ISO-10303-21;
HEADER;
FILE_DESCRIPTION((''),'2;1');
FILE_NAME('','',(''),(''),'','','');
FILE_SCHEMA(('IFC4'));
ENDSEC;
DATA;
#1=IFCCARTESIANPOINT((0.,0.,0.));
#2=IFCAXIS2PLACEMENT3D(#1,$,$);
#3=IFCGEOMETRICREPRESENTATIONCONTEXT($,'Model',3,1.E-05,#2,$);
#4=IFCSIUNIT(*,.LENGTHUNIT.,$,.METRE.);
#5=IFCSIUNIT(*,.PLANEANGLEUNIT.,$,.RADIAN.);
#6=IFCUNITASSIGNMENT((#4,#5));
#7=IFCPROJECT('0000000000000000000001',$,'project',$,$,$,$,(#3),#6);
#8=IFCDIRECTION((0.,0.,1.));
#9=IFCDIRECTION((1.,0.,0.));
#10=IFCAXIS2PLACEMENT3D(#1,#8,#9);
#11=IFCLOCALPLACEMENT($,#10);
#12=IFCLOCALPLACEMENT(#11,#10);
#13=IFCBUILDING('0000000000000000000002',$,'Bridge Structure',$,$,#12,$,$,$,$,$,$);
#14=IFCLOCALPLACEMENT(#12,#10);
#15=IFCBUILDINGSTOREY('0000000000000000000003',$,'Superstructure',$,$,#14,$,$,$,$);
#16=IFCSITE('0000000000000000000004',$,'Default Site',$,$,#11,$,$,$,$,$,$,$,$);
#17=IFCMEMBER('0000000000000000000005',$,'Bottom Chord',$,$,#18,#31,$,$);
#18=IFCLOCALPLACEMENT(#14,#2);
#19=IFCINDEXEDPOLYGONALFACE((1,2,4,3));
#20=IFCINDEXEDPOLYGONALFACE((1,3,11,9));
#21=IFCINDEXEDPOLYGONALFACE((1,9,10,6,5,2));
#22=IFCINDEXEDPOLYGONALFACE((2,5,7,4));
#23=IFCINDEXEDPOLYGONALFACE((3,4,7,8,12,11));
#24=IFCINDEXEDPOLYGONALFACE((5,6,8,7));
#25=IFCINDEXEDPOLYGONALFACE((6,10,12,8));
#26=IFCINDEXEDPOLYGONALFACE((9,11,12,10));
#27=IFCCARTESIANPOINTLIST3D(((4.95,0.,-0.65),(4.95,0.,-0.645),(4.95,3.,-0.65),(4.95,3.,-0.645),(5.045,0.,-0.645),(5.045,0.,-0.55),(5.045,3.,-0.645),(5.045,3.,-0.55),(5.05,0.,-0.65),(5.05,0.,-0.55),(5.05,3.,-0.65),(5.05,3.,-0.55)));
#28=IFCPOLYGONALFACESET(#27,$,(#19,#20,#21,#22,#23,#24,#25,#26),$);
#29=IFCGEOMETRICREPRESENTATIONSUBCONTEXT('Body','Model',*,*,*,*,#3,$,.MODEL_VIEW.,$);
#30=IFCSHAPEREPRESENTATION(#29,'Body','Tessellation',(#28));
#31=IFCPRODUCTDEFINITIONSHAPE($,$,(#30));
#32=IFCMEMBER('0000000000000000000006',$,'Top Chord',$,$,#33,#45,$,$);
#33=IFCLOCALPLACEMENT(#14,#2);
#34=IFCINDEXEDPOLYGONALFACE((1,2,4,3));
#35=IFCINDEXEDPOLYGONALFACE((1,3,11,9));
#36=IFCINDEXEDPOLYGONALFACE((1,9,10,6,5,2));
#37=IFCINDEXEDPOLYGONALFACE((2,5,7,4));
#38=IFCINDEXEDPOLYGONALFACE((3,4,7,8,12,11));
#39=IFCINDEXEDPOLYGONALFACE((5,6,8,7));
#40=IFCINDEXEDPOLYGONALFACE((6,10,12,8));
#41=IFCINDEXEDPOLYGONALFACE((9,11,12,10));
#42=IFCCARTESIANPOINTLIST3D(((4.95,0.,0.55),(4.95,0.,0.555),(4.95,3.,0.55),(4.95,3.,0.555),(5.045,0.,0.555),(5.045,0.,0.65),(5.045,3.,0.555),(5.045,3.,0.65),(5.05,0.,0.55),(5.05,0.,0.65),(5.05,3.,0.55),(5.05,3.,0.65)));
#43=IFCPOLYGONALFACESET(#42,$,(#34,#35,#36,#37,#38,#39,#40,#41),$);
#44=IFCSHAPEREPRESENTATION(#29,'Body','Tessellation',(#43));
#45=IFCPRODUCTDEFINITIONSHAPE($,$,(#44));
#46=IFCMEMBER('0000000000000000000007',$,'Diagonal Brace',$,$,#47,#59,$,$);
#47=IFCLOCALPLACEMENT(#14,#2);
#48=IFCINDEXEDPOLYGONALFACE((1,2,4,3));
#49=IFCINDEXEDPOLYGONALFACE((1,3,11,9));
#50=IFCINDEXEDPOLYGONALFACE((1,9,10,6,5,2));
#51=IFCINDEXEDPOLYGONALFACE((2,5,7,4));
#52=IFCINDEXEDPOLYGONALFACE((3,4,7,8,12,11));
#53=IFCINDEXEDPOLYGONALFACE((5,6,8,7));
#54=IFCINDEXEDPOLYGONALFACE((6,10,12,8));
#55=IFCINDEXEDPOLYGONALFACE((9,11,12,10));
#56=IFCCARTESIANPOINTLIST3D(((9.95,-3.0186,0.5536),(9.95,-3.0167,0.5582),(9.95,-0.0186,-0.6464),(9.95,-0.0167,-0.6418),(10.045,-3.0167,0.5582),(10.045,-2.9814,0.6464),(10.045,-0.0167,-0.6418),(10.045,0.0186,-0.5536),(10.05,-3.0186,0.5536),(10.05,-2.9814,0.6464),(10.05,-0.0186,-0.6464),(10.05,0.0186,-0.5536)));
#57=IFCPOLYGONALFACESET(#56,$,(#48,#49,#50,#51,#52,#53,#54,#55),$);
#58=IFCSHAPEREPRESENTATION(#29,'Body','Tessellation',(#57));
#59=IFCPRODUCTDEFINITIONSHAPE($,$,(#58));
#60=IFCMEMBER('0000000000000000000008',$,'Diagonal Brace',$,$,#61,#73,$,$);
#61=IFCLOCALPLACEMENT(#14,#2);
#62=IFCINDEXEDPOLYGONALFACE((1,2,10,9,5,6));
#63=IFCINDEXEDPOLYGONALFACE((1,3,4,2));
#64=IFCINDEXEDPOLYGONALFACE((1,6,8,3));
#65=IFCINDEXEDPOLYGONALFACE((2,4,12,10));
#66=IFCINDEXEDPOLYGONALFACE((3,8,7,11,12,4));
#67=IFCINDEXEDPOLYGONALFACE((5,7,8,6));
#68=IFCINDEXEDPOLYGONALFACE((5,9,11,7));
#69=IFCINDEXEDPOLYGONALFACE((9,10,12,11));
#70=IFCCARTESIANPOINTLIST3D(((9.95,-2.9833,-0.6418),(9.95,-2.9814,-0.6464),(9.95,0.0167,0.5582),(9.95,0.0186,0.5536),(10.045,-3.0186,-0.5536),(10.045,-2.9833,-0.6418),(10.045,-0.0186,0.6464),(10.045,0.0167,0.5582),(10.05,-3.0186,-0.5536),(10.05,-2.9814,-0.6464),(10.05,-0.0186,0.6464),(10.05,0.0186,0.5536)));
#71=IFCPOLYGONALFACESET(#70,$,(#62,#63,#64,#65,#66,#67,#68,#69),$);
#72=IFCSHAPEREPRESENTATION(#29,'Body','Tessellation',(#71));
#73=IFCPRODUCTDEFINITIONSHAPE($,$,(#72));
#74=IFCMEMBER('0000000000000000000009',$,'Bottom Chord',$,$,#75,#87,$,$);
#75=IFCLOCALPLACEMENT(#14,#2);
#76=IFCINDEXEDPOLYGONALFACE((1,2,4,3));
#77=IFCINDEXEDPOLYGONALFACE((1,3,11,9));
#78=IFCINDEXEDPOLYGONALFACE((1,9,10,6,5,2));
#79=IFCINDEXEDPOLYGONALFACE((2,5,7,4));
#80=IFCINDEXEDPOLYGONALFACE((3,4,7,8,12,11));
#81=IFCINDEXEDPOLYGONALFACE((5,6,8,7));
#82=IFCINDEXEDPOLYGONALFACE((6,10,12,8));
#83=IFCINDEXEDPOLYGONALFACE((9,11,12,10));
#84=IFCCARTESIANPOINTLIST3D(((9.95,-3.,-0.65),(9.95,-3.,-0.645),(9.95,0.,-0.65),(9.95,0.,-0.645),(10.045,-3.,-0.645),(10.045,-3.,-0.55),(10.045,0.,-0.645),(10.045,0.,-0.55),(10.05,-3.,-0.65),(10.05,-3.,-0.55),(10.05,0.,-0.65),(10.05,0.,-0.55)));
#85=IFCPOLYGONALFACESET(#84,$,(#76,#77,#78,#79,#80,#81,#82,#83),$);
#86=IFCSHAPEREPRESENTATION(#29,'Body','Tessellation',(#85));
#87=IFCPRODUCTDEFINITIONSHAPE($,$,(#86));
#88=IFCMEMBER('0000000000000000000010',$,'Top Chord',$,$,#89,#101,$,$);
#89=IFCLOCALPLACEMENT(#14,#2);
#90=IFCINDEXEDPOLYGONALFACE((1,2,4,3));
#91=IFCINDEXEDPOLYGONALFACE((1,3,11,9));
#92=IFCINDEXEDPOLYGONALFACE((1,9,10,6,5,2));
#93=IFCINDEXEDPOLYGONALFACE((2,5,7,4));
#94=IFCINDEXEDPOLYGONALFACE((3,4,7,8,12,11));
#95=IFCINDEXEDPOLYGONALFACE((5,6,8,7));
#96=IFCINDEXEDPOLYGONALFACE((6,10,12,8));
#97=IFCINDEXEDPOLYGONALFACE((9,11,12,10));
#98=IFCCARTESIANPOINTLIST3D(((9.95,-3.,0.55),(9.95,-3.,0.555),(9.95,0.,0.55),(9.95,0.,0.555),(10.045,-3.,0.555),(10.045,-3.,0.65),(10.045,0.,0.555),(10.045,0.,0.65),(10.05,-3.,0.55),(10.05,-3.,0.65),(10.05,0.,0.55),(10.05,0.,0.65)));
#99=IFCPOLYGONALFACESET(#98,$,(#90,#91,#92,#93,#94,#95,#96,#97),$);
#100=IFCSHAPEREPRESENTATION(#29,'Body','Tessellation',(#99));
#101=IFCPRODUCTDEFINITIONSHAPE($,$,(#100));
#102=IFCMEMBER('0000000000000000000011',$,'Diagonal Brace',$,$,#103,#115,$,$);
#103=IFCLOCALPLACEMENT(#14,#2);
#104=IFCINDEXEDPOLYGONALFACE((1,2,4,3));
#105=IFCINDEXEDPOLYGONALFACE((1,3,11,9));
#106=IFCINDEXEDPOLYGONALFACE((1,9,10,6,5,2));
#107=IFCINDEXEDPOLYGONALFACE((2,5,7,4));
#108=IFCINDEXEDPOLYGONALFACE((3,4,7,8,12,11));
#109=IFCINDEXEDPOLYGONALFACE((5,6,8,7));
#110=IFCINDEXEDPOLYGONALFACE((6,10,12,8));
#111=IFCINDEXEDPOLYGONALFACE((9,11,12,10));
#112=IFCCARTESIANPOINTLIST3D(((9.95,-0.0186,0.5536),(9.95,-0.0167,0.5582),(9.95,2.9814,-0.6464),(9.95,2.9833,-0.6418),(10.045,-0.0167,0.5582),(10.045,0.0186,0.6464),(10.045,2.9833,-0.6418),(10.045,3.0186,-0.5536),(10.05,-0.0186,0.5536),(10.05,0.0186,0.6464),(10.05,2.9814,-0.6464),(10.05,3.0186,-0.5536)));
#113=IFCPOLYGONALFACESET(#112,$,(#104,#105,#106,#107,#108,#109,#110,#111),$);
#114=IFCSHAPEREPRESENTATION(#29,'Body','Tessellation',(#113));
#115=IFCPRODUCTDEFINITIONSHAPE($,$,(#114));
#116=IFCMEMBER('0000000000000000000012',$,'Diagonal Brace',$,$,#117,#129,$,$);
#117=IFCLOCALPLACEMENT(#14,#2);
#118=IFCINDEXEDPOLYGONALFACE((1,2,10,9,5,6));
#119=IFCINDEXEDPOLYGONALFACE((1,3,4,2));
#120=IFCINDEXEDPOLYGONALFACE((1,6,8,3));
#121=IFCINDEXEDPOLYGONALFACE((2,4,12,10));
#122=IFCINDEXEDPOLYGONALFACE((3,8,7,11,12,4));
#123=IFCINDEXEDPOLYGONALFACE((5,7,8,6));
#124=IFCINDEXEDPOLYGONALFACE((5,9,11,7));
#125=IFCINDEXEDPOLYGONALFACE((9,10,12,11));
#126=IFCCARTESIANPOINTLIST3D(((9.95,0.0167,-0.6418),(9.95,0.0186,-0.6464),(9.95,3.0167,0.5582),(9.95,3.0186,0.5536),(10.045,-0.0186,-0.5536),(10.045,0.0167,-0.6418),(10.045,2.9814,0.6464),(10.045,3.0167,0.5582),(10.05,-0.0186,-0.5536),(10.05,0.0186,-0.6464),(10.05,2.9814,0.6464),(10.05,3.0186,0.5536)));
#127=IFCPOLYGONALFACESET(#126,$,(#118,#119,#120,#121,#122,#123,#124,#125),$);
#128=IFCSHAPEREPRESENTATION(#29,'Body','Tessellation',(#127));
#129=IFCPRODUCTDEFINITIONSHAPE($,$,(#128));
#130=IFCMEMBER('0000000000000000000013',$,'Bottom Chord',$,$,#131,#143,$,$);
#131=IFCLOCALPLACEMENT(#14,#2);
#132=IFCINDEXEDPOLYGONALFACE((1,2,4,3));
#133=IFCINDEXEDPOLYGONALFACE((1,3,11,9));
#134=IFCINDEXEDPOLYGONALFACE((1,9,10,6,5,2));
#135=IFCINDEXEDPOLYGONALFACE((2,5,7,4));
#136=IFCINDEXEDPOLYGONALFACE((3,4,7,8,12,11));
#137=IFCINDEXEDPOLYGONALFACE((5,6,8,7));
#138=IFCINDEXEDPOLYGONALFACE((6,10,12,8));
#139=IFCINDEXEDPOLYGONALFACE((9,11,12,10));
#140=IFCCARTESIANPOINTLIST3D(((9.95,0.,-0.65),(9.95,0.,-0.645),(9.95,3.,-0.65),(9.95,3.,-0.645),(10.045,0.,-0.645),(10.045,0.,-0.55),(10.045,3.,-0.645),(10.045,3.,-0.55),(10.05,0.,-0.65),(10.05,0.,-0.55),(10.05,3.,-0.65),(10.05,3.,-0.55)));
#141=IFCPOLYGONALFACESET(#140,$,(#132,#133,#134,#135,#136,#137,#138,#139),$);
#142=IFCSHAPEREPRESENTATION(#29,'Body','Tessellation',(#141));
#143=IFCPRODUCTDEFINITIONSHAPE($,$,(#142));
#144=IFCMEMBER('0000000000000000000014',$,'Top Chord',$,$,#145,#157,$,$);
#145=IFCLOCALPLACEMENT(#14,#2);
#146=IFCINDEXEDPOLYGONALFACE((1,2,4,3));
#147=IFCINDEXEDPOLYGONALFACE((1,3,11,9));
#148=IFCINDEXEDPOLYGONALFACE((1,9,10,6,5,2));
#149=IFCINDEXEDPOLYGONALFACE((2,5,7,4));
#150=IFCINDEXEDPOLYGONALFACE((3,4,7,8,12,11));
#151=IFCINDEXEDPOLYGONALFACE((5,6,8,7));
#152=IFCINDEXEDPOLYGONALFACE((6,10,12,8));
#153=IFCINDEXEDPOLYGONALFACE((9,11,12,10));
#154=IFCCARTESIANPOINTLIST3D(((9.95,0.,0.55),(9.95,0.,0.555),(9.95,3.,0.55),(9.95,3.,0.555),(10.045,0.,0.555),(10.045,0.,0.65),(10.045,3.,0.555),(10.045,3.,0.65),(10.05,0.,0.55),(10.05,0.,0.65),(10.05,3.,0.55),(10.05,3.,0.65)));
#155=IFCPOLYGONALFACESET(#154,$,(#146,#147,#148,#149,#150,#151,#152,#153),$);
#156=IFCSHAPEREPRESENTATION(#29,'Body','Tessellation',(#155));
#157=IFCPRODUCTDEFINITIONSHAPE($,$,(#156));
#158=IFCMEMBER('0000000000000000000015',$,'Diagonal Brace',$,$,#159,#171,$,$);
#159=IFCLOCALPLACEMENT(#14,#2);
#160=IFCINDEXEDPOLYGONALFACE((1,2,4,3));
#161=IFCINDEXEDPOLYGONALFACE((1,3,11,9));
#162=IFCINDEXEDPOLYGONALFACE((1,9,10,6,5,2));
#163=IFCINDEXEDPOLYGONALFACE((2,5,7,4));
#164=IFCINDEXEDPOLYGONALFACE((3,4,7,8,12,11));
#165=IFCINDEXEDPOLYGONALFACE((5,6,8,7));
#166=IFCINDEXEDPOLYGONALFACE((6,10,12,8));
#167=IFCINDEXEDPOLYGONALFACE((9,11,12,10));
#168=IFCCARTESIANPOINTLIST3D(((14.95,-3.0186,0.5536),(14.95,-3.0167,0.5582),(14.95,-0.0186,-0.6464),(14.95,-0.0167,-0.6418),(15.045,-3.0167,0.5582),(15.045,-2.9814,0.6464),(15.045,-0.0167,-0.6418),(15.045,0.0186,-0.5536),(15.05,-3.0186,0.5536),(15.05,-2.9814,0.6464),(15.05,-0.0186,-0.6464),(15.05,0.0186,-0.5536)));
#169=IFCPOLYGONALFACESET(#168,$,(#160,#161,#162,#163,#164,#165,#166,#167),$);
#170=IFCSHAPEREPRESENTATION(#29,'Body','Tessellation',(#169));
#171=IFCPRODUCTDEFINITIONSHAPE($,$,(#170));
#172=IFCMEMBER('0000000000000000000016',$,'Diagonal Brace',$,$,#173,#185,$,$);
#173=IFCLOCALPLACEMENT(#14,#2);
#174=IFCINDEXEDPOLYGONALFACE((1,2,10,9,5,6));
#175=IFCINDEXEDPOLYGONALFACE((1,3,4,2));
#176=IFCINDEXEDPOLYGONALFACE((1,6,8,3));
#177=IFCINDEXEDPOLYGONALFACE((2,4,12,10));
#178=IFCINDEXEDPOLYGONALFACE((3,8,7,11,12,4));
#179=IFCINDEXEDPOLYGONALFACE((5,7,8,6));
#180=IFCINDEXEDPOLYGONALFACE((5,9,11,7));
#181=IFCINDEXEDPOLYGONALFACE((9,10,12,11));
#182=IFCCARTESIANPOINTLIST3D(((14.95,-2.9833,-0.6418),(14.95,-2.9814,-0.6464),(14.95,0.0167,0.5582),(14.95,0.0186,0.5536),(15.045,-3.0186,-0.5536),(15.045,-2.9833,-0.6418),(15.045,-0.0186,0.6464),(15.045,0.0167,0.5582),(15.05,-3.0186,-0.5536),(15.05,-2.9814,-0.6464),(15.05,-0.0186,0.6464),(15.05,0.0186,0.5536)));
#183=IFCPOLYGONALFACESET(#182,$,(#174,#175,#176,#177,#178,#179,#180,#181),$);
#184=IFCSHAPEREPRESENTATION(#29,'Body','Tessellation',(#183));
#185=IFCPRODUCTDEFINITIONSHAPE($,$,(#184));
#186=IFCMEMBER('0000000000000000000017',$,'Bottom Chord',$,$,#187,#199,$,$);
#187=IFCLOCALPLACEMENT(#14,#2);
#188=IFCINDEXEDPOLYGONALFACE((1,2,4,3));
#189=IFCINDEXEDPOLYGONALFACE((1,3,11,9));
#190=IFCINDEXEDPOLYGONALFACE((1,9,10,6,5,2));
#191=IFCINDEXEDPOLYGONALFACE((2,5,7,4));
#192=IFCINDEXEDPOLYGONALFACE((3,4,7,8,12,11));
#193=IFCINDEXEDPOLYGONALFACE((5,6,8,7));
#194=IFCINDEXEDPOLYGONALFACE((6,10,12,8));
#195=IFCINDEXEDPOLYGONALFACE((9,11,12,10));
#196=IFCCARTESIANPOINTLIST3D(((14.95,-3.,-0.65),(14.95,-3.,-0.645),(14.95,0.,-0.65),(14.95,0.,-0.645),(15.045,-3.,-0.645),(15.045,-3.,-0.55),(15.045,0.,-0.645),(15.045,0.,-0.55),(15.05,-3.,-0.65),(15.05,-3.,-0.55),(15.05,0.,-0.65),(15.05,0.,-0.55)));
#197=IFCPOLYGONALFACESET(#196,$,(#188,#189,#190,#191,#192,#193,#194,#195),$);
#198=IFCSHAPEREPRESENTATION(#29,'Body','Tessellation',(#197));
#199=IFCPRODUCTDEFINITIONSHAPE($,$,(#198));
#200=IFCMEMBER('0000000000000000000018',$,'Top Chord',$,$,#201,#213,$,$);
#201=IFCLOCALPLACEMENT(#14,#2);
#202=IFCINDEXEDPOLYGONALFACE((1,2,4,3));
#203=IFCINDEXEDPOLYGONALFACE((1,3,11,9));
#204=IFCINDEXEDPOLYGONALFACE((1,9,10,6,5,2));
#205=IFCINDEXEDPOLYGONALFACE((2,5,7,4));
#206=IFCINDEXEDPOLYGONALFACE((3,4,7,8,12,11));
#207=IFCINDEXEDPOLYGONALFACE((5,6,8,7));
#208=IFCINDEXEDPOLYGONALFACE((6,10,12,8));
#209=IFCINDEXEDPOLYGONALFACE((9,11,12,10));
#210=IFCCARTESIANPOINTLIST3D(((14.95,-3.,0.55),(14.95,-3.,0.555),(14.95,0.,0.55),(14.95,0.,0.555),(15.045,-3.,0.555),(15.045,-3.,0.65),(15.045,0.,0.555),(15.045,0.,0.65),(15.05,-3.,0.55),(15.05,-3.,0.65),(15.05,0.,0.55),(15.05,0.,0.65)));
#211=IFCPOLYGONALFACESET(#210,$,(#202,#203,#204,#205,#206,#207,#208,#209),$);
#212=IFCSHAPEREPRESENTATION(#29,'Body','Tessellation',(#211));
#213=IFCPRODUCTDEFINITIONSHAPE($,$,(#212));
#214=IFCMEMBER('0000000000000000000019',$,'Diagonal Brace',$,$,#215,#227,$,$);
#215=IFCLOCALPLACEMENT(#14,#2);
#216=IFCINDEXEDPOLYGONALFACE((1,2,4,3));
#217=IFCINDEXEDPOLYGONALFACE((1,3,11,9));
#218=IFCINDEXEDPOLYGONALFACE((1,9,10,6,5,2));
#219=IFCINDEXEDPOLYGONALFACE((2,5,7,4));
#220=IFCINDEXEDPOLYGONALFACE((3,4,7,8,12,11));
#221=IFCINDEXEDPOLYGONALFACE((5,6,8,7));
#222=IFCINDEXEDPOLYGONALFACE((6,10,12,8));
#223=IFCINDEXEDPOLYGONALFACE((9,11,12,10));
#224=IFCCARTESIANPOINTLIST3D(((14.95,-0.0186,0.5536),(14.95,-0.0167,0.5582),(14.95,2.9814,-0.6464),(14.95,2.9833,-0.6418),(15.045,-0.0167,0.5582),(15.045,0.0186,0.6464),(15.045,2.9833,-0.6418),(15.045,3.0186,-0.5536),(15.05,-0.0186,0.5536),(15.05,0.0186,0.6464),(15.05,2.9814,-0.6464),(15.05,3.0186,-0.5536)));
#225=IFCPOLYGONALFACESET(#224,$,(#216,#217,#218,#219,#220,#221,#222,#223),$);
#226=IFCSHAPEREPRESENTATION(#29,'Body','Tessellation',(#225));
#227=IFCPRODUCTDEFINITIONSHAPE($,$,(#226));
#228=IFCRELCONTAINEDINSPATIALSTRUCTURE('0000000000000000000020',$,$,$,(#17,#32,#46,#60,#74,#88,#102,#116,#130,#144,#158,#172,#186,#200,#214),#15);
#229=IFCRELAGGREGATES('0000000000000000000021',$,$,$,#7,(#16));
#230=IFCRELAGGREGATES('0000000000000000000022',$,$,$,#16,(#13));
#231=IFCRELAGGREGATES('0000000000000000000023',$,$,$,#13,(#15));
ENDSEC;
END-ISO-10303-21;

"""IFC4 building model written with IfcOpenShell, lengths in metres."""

from ifc_helpers import new_model, si_unit, frame, origin, origin_with_axes, origin_2d_with_axis, place, context, subcontext, project, spatial, l_section, extrude, element, save


model = new_model("IFC4")

# Units and contexts
model_context = context("Model", 3, precision=1e-05, world=origin())
body_context = subcontext(model_context, "Body", "Model", "MODEL_VIEW")
ifc_project = project(units=[si_unit("LENGTHUNIT", "METRE"), si_unit("PLANEANGLEUNIT", "RADIAN")], contexts=[model_context])

# Site, building, storey
site_placement = place(None, origin_with_axes())
site = spatial("IfcSite", under=ifc_project, at=site_placement, Name="Default Site")
building_placement = place(site_placement, origin_with_axes())
building = spatial("IfcBuilding", under=site, at=building_placement, Name="Bridge Structure")
storey_placement = place(building_placement, origin_with_axes())
storey = spatial("IfcBuildingStorey", under=building, at=storey_placement, Name="Superstructure")

# Members
for number, where, z_axis, x_axis, name in (
    (1, (5.0, 0.0, -0.6), (0.0, 1.0, 0.0), (-1.0, 0.0, 0.0), "Bottom Chord"),
    (2, (5.0, 0.0, 0.6), (0.0, 1.0, 0.0), (-1.0, 0.0, 0.0), "Top Chord"),
):
    element("IfcMember", number, at=place(storey_placement, frame(where, z_axis=z_axis, x_axis=x_axis)), inside=storey, Name=name, context=body_context, shape_type="SweptSolid", body=[
        extrude(l_section(Depth=0.1, Width=0.1, Thickness=0.005, at=origin_2d_with_axis()), origin_with_axes(), (0.0, 0.0, 1.0), 3.0),
    ])
for number, where, z_axis, x_axis, name in (
    (3, (10.0, -3.0, 0.6), (0.0, 0.928477, -0.371391), (-1.0, 0.0, 0.0), "Diagonal Brace"),
    (4, (10.0, -3.0, -0.6), (0.0, 0.928477, 0.371391), (-1.0, 0.0, 0.0), "Diagonal Brace"),
):
    element("IfcMember", number, at=place(storey_placement, frame(where, z_axis=z_axis, x_axis=x_axis)), inside=storey, Name=name, context=body_context, shape_type="SweptSolid", body=[
        extrude(l_section(Depth=0.1, Width=0.1, Thickness=0.005, at=origin_2d_with_axis()), origin_with_axes(), (0.0, 0.0, 1.0), 3.2311),
    ])
for number, where, z_axis, x_axis, name in (
    (5, (10.0, -3.0, -0.6), (0.0, 1.0, 0.0), (-1.0, 0.0, 0.0), "Bottom Chord"),
    (6, (10.0, -3.0, 0.6), (0.0, 1.0, 0.0), (-1.0, 0.0, 0.0), "Top Chord"),
):
    element("IfcMember", number, at=place(storey_placement, frame(where, z_axis=z_axis, x_axis=x_axis)), inside=storey, Name=name, context=body_context, shape_type="SweptSolid", body=[
        extrude(l_section(Depth=0.1, Width=0.1, Thickness=0.005, at=origin_2d_with_axis()), origin_with_axes(), (0.0, 0.0, 1.0), 3.0),
    ])
for number, where, z_axis, x_axis, name in (
    (7, (10.0, 0.0, 0.6), (0.0, 0.928477, -0.371391), (-1.0, 0.0, 0.0), "Diagonal Brace"),
    (8, (10.0, 0.0, -0.6), (0.0, 0.928477, 0.371391), (-1.0, 0.0, 0.0), "Diagonal Brace"),
):
    element("IfcMember", number, at=place(storey_placement, frame(where, z_axis=z_axis, x_axis=x_axis)), inside=storey, Name=name, context=body_context, shape_type="SweptSolid", body=[
        extrude(l_section(Depth=0.1, Width=0.1, Thickness=0.005, at=origin_2d_with_axis()), origin_with_axes(), (0.0, 0.0, 1.0), 3.2311),
    ])
for number, where, z_axis, x_axis, name in (
    (9, (10.0, 0.0, -0.6), (0.0, 1.0, 0.0), (-1.0, 0.0, 0.0), "Bottom Chord"),
    (10, (10.0, 0.0, 0.6), (0.0, 1.0, 0.0), (-1.0, 0.0, 0.0), "Top Chord"),
):
    element("IfcMember", number, at=place(storey_placement, frame(where, z_axis=z_axis, x_axis=x_axis)), inside=storey, Name=name, context=body_context, shape_type="SweptSolid", body=[
        extrude(l_section(Depth=0.1, Width=0.1, Thickness=0.005, at=origin_2d_with_axis()), origin_with_axes(), (0.0, 0.0, 1.0), 3.0),
    ])
for number, where, z_axis, x_axis, name in (
    (11, (15.0, -3.0, 0.6), (0.0, 0.928477, -0.371391), (-1.0, 0.0, 0.0), "Diagonal Brace"),
    (12, (15.0, -3.0, -0.6), (0.0, 0.928477, 0.371391), (-1.0, 0.0, 0.0), "Diagonal Brace"),
):
    element("IfcMember", number, at=place(storey_placement, frame(where, z_axis=z_axis, x_axis=x_axis)), inside=storey, Name=name, context=body_context, shape_type="SweptSolid", body=[
        extrude(l_section(Depth=0.1, Width=0.1, Thickness=0.005, at=origin_2d_with_axis()), origin_with_axes(), (0.0, 0.0, 1.0), 3.2311),
    ])
for number, where, z_axis, x_axis, name in (
    (13, (15.0, -3.0, -0.6), (0.0, 1.0, 0.0), (-1.0, 0.0, 0.0), "Bottom Chord"),
    (14, (15.0, -3.0, 0.6), (0.0, 1.0, 0.0), (-1.0, 0.0, 0.0), "Top Chord"),
):
    element("IfcMember", number, at=place(storey_placement, frame(where, z_axis=z_axis, x_axis=x_axis)), inside=storey, Name=name, context=body_context, shape_type="SweptSolid", body=[
        extrude(l_section(Depth=0.1, Width=0.1, Thickness=0.005, at=origin_2d_with_axis()), origin_with_axes(), (0.0, 0.0, 1.0), 3.0),
    ])
for number, where, z_axis, x_axis, name in (
    (15, (15.0, 0.0, 0.6), (0.0, 0.928477, -0.371391), (-1.0, 0.0, 0.0), "Diagonal Brace"),
):
    element("IfcMember", number, at=place(storey_placement, frame(where, z_axis=z_axis, x_axis=x_axis)), inside=storey, Name=name, context=body_context, shape_type="SweptSolid", body=[
        extrude(l_section(Depth=0.1, Width=0.1, Thickness=0.005, at=origin_2d_with_axis()), origin_with_axes(), (0.0, 0.0, 1.0), 3.2311),
    ])

save(model, "model.ifc")
